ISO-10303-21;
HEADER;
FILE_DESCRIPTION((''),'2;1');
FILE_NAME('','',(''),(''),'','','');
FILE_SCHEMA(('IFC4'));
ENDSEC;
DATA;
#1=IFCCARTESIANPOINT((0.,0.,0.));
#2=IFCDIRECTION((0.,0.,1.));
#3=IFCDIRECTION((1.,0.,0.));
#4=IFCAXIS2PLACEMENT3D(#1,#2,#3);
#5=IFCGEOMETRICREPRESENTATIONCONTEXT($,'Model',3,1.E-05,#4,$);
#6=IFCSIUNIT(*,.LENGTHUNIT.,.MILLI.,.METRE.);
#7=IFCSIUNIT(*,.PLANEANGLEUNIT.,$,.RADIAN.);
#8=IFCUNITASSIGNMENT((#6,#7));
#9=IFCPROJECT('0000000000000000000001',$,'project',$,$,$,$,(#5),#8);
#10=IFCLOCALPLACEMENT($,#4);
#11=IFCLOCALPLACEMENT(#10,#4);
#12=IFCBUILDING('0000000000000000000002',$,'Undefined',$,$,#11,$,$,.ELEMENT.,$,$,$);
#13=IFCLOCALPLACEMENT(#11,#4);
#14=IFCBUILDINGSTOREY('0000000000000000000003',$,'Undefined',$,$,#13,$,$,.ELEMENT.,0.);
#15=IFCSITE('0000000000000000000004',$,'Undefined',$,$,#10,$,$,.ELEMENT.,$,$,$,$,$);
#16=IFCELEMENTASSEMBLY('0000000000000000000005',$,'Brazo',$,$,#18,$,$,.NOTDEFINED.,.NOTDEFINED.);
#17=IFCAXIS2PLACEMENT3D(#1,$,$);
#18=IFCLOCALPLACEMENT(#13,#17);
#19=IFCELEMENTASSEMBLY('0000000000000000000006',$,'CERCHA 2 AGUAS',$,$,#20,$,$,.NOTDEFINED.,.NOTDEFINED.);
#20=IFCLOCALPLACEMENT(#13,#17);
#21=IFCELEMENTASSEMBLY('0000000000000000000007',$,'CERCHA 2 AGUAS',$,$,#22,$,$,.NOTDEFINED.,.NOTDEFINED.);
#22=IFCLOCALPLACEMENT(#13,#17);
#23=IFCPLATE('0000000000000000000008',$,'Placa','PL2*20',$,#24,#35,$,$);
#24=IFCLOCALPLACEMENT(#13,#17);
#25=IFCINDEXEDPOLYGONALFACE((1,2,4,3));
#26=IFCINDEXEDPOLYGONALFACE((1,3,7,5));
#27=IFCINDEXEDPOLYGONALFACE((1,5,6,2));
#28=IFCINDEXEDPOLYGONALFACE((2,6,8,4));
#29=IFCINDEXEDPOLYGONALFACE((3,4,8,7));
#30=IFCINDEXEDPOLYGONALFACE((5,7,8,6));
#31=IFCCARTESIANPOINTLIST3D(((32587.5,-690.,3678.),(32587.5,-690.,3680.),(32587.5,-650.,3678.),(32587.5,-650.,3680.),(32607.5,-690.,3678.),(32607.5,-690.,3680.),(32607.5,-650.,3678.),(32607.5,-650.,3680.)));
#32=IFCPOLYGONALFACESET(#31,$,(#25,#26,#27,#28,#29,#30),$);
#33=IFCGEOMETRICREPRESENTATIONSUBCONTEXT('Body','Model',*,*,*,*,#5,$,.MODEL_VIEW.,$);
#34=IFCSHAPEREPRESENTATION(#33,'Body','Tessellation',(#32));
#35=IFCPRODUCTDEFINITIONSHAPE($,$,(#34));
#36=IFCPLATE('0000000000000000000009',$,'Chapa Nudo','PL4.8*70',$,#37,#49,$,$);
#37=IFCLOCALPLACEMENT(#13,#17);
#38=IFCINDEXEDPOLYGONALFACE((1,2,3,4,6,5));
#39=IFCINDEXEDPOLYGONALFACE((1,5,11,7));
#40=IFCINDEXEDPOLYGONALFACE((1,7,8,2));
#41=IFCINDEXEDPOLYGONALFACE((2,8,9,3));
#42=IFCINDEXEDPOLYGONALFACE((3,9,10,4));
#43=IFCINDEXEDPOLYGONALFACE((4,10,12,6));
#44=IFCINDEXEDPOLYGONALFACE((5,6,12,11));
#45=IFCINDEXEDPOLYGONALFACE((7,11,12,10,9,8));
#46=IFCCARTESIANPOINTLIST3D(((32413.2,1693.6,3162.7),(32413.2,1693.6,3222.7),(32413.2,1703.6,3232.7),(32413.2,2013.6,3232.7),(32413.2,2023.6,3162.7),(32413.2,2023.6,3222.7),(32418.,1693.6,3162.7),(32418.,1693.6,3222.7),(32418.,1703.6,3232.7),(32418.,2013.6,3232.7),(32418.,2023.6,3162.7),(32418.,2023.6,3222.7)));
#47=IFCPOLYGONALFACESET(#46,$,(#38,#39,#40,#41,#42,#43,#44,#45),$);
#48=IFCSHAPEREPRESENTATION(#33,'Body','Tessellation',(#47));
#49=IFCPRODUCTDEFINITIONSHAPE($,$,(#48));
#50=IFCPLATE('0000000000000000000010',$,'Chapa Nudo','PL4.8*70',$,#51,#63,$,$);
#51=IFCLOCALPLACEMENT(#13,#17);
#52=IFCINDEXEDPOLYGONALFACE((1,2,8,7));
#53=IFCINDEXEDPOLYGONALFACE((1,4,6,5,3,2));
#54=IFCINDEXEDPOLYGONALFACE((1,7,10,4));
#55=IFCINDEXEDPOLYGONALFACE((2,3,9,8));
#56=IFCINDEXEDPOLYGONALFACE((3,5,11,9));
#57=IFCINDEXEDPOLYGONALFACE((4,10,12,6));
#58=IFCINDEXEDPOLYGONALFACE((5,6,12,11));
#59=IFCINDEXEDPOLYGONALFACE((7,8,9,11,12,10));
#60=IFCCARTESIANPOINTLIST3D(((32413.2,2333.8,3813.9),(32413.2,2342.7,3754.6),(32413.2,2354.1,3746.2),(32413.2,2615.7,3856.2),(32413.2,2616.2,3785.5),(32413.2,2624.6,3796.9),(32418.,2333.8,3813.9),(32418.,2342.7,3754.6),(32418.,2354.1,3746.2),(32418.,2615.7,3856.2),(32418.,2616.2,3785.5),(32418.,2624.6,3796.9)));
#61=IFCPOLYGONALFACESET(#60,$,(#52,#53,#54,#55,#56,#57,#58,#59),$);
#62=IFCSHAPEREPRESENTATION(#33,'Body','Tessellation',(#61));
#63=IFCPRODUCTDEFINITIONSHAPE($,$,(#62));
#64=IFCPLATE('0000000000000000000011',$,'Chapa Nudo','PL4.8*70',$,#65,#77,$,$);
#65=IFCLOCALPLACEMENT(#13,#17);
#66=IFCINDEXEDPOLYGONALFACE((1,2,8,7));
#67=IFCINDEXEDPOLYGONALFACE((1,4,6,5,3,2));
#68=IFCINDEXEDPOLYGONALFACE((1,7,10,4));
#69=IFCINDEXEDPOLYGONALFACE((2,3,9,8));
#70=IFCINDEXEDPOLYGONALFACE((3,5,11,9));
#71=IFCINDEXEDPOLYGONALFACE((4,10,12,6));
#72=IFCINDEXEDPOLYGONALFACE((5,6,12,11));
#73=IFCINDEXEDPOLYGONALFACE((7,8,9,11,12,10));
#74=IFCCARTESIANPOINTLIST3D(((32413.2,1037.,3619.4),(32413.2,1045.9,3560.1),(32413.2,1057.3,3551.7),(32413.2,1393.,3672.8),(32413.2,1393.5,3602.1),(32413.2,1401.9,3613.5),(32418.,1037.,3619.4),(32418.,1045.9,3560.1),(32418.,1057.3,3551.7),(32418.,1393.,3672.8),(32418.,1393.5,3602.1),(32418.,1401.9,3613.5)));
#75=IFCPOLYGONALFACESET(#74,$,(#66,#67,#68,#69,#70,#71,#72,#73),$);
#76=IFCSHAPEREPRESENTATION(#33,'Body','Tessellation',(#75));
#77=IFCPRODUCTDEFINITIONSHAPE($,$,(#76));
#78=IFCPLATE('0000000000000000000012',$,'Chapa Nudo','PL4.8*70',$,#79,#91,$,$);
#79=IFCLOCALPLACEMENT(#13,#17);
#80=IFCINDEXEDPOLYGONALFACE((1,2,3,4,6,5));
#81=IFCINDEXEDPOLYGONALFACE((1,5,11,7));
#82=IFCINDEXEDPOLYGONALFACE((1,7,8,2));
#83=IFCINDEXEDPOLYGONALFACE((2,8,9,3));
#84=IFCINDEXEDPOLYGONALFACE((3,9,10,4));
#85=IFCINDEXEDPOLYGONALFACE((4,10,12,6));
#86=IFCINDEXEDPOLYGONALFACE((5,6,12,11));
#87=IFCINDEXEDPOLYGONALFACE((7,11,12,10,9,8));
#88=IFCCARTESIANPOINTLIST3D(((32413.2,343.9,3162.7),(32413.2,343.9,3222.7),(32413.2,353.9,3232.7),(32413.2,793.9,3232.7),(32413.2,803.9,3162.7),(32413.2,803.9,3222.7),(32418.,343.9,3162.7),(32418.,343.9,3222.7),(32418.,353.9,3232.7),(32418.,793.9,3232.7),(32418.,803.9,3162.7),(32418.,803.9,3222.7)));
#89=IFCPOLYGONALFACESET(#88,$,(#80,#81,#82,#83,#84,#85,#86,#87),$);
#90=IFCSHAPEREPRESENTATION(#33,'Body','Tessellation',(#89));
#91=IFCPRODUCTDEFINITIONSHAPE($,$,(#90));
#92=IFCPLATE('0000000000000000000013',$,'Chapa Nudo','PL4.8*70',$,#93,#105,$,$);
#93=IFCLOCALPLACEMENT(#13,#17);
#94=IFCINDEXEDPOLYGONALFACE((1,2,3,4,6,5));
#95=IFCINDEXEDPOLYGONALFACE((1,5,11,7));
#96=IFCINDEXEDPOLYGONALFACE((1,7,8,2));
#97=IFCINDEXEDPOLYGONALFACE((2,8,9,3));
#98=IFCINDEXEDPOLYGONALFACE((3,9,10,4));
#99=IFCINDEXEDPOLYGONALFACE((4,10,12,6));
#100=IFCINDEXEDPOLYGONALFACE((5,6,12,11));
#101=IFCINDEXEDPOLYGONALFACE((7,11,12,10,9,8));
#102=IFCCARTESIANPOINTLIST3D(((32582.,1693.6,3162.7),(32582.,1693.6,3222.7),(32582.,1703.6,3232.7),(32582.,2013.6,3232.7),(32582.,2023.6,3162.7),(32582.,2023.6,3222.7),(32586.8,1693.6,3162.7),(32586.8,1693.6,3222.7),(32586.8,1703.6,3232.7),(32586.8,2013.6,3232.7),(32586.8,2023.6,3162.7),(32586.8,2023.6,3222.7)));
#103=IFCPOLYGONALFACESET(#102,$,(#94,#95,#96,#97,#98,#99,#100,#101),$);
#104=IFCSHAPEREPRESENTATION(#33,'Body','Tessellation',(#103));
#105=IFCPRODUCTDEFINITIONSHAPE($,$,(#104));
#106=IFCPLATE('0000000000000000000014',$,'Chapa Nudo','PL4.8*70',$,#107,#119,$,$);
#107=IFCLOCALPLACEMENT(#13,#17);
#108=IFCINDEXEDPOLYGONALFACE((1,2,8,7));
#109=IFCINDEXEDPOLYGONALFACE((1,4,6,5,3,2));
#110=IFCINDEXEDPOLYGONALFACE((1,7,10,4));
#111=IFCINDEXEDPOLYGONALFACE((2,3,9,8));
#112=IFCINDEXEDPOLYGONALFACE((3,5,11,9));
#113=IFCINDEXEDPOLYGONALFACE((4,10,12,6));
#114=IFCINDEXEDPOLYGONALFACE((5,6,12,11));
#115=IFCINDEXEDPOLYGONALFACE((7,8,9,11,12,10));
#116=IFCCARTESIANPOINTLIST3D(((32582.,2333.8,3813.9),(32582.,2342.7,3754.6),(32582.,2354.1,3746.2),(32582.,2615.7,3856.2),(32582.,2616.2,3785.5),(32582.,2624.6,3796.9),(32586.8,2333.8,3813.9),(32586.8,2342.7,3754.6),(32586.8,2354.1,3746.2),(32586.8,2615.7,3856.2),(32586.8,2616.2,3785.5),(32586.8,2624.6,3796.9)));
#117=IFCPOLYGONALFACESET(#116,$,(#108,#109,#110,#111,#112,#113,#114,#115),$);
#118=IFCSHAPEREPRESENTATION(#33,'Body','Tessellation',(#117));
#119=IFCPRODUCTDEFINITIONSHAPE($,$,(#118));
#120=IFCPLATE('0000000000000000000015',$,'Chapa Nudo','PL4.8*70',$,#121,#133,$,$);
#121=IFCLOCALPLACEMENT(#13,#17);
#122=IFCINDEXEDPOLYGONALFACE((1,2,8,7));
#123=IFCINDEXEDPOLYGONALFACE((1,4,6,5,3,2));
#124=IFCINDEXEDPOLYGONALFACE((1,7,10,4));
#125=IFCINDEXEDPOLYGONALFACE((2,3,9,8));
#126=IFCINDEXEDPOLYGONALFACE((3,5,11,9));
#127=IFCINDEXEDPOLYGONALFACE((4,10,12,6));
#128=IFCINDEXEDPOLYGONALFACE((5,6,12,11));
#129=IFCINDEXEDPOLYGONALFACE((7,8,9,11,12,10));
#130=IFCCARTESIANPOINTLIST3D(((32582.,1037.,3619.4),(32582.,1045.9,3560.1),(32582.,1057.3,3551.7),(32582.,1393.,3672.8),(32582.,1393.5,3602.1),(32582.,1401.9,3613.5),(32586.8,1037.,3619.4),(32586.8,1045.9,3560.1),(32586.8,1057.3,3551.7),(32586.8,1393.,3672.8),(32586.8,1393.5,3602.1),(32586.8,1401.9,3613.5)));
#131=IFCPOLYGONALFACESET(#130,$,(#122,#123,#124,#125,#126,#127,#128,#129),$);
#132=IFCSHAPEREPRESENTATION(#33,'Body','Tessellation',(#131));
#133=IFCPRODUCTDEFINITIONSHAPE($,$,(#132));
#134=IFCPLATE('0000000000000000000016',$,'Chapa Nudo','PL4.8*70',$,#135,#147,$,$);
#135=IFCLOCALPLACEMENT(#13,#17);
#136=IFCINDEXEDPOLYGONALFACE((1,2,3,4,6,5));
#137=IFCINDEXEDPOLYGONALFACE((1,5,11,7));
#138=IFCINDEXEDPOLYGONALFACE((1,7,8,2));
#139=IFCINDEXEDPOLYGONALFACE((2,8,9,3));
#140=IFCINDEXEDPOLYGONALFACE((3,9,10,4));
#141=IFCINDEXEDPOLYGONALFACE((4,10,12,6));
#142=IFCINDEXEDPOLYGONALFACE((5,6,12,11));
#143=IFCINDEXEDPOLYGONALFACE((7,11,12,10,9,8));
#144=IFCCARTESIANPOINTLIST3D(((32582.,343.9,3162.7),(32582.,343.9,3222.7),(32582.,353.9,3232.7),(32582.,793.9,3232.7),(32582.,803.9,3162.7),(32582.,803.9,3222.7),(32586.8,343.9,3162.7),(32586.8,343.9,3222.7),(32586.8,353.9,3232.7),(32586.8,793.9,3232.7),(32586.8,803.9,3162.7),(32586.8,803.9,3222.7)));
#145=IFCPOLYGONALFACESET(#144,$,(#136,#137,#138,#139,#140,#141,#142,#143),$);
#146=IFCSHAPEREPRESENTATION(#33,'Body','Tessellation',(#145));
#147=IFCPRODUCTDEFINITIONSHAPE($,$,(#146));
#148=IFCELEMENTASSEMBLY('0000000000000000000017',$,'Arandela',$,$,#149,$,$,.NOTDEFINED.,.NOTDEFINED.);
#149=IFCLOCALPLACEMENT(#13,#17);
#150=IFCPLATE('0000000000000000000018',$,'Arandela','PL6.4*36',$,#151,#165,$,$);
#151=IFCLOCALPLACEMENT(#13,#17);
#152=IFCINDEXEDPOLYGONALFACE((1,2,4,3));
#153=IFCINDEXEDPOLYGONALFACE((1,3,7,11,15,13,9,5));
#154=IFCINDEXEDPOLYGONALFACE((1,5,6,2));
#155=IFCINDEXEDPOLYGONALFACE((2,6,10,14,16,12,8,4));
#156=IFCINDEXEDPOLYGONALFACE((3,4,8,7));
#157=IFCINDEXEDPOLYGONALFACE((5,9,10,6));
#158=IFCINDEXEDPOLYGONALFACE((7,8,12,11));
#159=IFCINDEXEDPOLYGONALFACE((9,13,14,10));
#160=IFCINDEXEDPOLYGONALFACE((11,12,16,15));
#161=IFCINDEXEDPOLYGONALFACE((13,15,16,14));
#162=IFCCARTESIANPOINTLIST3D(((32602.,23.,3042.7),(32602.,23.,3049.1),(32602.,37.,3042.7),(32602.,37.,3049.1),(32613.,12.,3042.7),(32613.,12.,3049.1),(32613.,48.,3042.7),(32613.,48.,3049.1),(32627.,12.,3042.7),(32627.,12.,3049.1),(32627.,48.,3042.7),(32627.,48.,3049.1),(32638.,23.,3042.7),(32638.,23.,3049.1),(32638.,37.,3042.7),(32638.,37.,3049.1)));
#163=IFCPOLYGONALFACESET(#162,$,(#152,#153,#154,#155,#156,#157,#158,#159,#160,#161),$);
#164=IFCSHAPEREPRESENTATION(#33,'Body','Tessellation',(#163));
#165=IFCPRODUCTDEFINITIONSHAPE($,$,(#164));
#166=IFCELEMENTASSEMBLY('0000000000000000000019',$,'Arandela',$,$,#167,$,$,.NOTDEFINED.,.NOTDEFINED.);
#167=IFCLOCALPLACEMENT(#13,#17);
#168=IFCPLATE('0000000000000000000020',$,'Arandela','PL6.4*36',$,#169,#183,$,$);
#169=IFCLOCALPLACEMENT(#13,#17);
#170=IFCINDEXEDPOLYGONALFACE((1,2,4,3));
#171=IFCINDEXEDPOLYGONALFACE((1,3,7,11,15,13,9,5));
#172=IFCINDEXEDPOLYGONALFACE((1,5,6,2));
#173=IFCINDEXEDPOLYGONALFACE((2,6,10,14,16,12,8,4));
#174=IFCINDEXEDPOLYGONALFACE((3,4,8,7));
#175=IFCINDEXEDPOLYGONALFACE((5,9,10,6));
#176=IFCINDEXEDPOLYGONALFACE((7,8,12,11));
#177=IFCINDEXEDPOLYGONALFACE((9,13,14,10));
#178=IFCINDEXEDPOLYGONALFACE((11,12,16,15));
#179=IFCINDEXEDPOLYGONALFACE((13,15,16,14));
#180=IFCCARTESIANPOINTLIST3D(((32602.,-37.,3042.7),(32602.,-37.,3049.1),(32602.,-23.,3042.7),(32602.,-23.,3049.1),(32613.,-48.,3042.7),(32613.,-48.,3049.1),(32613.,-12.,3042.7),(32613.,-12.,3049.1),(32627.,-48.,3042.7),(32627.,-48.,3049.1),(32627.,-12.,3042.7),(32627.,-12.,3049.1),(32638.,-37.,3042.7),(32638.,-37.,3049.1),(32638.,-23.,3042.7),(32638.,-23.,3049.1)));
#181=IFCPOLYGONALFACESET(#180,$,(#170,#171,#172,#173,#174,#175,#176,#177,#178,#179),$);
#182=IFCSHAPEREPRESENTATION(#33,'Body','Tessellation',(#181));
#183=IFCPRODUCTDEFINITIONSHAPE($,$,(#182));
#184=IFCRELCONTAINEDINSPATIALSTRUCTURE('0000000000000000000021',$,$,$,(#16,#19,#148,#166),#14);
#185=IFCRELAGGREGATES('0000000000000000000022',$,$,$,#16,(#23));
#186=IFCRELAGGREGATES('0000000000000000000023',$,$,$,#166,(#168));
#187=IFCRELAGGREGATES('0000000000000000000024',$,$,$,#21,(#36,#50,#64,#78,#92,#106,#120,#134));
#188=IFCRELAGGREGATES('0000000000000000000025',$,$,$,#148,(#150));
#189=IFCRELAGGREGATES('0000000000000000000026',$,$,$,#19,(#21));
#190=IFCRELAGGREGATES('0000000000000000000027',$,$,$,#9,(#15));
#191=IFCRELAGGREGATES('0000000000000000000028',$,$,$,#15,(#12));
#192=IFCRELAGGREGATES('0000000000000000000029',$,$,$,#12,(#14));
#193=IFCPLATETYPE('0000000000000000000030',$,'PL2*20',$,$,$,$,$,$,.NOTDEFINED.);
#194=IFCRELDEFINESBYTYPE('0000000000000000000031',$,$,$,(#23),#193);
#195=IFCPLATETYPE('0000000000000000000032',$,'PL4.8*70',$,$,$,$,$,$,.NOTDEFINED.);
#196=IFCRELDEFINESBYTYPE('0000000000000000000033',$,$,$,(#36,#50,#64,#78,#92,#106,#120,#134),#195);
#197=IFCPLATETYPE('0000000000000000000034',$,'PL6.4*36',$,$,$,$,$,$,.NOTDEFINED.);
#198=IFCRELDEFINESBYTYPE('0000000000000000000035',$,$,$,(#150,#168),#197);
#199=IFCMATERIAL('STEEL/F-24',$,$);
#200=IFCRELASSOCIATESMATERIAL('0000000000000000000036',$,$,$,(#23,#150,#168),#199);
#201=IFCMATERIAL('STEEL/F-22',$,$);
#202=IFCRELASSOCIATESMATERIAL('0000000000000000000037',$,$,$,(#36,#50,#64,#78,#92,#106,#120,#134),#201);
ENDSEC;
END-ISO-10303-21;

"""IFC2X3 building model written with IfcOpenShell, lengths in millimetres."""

from ifc_helpers import new_model, si_unit, frame, origin_with_axes, place, context, subcontext, project, spatial, polyline, outline, extrude, material, type_object, element, aggregate, save


model = new_model("IFC2X3")

# Units and contexts
model_context = context("Model", 3, precision=1e-05, world=origin_with_axes())
body_context = subcontext(model_context, "Body", "Model", "MODEL_VIEW")
ifc_project = project(units=[si_unit("LENGTHUNIT", "METRE", prefix="MILLI"), si_unit("PLANEANGLEUNIT", "RADIAN")], contexts=[model_context])

# Site, building, storey
site_placement = place(None, origin_with_axes())
site = spatial("IfcSite", under=ifc_project, at=site_placement, Name="Undefined", CompositionType="ELEMENT")
building_placement = place(site_placement, origin_with_axes())
building = spatial("IfcBuilding", under=site, at=building_placement, Name="Undefined", CompositionType="ELEMENT")
storey_placement = place(building_placement, origin_with_axes())
storey = spatial("IfcBuildingStorey", under=building, at=storey_placement, Name="Undefined", CompositionType="ELEMENT", Elevation=0.0)

# Element assembly
assembly_1_placement = place(storey_placement, origin_with_axes())
assembly_1 = element("IfcElementAssembly", 1, at=assembly_1_placement, inside=storey, Name="Brazo", AssemblyPlace="NOTDEFINED", PredefinedType="NOTDEFINED")

# Element assemblies
assembly_2_placement = place(storey_placement, origin_with_axes())
assembly_2 = element("IfcElementAssembly", 2, at=assembly_2_placement, inside=storey, Name="CERCHA 2 AGUAS", AssemblyPlace="NOTDEFINED", PredefinedType="NOTDEFINED")
assembly_3_placement = place(assembly_2_placement, origin_with_axes())
assembly_3 = element("IfcElementAssembly", 3, at=assembly_3_placement, Name="CERCHA 2 AGUAS", AssemblyPlace="NOTDEFINED", PredefinedType="NOTDEFINED")
ifc_material_1 = material(Name="STEEL/F-22")

# Shared definitions
ifc_material_2 = material(Name="STEEL/F-24")

# Plates
plate_type_1 = type_object("IfcPlateType", Name="PL2*20", PredefinedType="NOTDEFINED")
plate_1_placement = place(assembly_1_placement, frame((32587.5, -690.0, 3679.0), z_axis=(0.0, 0.000121, -1.0), x_axis=(-0.000071, 1.0, 0.000121)))
plate_1 = element("IfcPlate", 4, at=plate_1_placement, type_object=plate_type_1, material=ifc_material_2, Name="Placa", Description="PL2*20", context=body_context, shape_type="SweptSolid", body=[
    extrude(outline(polyline([(0.0, 0.0), (40.0, 0.0), (40.0, 20.0), (0.0, 20.0), (0.0, 0.0)])), frame((0.0, 0.0, -1.0), z_axis=(0.0, 0.0, 1.0), x_axis=(1.0, 0.0, 0.0)), (0.0, 0.0, 1.0), 2.0),
])
aggregate(assembly_1, [plate_1])
plate_type_2 = type_object("IfcPlateType", Name="PL4.8*70", PredefinedType="NOTDEFINED")
plate_2_placement = place(assembly_3_placement, frame((32415.6, 1693.6, 3232.7), z_axis=(1.0, 0.0, 0.0), x_axis=(0.0, 0.0, -1.0)))
plate_2 = element("IfcPlate", 5, at=plate_2_placement, type_object=plate_type_2, material=ifc_material_1, Name="Chapa Nudo", Description="PL4.8*70", context=body_context, shape_type="SweptSolid", body=[
    extrude(outline(polyline([(0.0, 10.0), (10.0, 0.0), (70.0, 0.0), (70.0, 330.0), (10.0, 330.0), (0.0, 320.0), (0.0, 10.0)])), frame((0.0, 0.0, -2.4), z_axis=(0.0, 0.0, 1.0), x_axis=(1.0, 0.0, 0.0)), (0.0, 0.0, 1.0), 4.8),
])
plate_3_placement = place(assembly_3_placement, frame((32415.6, 2333.8, 3813.9), z_axis=(1.0, 0.0, 0.0), x_axis=(0.0, 0.14834, -0.988936)))
plate_3 = element("IfcPlate", 6, at=plate_3_placement, type_object=plate_type_2, material=ifc_material_1, Name="Chapa Nudo", Description="PL4.8*70", context=body_context, shape_type="SweptSolid", body=[
    extrude(outline(polyline([(0.0, 0.0), (60.0, 0.0), (70.0, 10.0), (70.0, 275.0), (60.0, 285.0), (0.0, 285.0), (0.0, 0.0)])), frame((0.0, 0.0, -2.4), z_axis=(0.0, 0.0, 1.0), x_axis=(1.0, 0.0, 0.0)), (0.0, 0.0, 1.0), 4.8),
])
plate_4_placement = place(assembly_3_placement, frame((32415.6, 1037.0, 3619.4), z_axis=(1.0, 0.0, 0.0), x_axis=(0.0, 0.148337, -0.988937)))
plate_4 = element("IfcPlate", 7, at=plate_4_placement, type_object=plate_type_2, material=ifc_material_1, Name="Chapa Nudo", Description="PL4.8*70", context=body_context, shape_type="SweptSolid", body=[
    extrude(outline(polyline([(0.0, 0.0), (60.0, 0.0), (70.0, 10.0), (70.0, 350.0), (60.0, 360.0), (0.0, 360.0), (0.0, 0.0)])), frame((0.0, 0.0, -2.4), z_axis=(0.0, 0.0, 1.0), x_axis=(1.0, 0.0, 0.0)), (0.0, 0.0, 1.0), 4.8),
])
plate_5_placement = place(assembly_3_placement, frame((32415.6, 343.9, 3232.7), z_axis=(1.0, 0.0, 0.0), x_axis=(0.0, 0.0, -1.0)))
plate_5 = element("IfcPlate", 8, at=plate_5_placement, type_object=plate_type_2, material=ifc_material_1, Name="Chapa Nudo", Description="PL4.8*70", context=body_context, shape_type="SweptSolid", body=[
    extrude(outline(polyline([(0.0, 10.0), (10.0, 0.0), (70.0, 0.0), (70.0, 460.0), (10.0, 460.0), (0.0, 450.0), (0.0, 10.0)])), frame((0.0, 0.0, -2.4), z_axis=(0.0, 0.0, 1.0), x_axis=(1.0, 0.0, 0.0)), (0.0, 0.0, 1.0), 4.8),
])
plate_6_placement = place(assembly_3_placement, frame((32584.4, 1693.6, 3232.7), z_axis=(1.0, 0.0, 0.0), x_axis=(0.0, 0.0, -1.0)))
plate_6 = element("IfcPlate", 9, at=plate_6_placement, type_object=plate_type_2, material=ifc_material_1, Name="Chapa Nudo", Description="PL4.8*70", context=body_context, shape_type="SweptSolid", body=[
    extrude(outline(polyline([(0.0, 10.0), (10.0, 0.0), (70.0, 0.0), (70.0, 330.0), (10.0, 330.0), (0.0, 320.0), (0.0, 10.0)])), frame((0.0, 0.0, -2.4), z_axis=(0.0, 0.0, 1.0), x_axis=(1.0, 0.0, 0.0)), (0.0, 0.0, 1.0), 4.8),
])
plate_7_placement = place(assembly_3_placement, frame((32584.4, 2333.8, 3813.9), z_axis=(1.0, 0.0, 0.0), x_axis=(0.0, 0.14834, -0.988936)))
plate_7 = element("IfcPlate", 10, at=plate_7_placement, type_object=plate_type_2, material=ifc_material_1, Name="Chapa Nudo", Description="PL4.8*70", context=body_context, shape_type="SweptSolid", body=[
    extrude(outline(polyline([(0.0, 0.0), (60.0, 0.0), (70.0, 10.0), (70.0, 275.0), (60.0, 285.0), (0.0, 285.0), (0.0, 0.0)])), frame((0.0, 0.0, -2.4), z_axis=(0.0, 0.0, 1.0), x_axis=(1.0, 0.0, 0.0)), (0.0, 0.0, 1.0), 4.8),
])
plate_8_placement = place(assembly_3_placement, frame((32584.4, 1037.0, 3619.4), z_axis=(1.0, 0.0, 0.0), x_axis=(0.0, 0.148337, -0.988937)))
plate_8 = element("IfcPlate", 11, at=plate_8_placement, type_object=plate_type_2, material=ifc_material_1, Name="Chapa Nudo", Description="PL4.8*70", context=body_context, shape_type="SweptSolid", body=[
    extrude(outline(polyline([(0.0, 0.0), (60.0, 0.0), (70.0, 10.0), (70.0, 350.0), (60.0, 360.0), (0.0, 360.0), (0.0, 0.0)])), frame((0.0, 0.0, -2.4), z_axis=(0.0, 0.0, 1.0), x_axis=(1.0, 0.0, 0.0)), (0.0, 0.0, 1.0), 4.8),
])
plate_9_placement = place(assembly_3_placement, frame((32584.4, 343.9, 3232.7), z_axis=(1.0, 0.0, 0.0), x_axis=(0.0, 0.0, -1.0)))
plate_9 = element("IfcPlate", 12, at=plate_9_placement, type_object=plate_type_2, material=ifc_material_1, Name="Chapa Nudo", Description="PL4.8*70", context=body_context, shape_type="SweptSolid", body=[
    extrude(outline(polyline([(0.0, 10.0), (10.0, 0.0), (70.0, 0.0), (70.0, 460.0), (10.0, 460.0), (0.0, 450.0), (0.0, 10.0)])), frame((0.0, 0.0, -2.4), z_axis=(0.0, 0.0, 1.0), x_axis=(1.0, 0.0, 0.0)), (0.0, 0.0, 1.0), 4.8),
])

# Element assemblies, plates
assembly_4_placement = place(storey_placement, origin_with_axes())
assembly_4 = element("IfcElementAssembly", 13, at=assembly_4_placement, inside=storey, Name="Arandela", AssemblyPlace="NOTDEFINED", PredefinedType="NOTDEFINED")
plate_type_3 = type_object("IfcPlateType", Name="PL6.4*36", PredefinedType="NOTDEFINED")
plate_10_placement = place(assembly_4_placement, frame((32602.0, 48.0, 3045.9), z_axis=(0.0, 0.0, 1.0), x_axis=(0.0, -1.0, 0.0)))
plate_10 = element("IfcPlate", 14, at=plate_10_placement, type_object=plate_type_3, material=ifc_material_2, Name="Arandela", Description="PL6.4*36", context=body_context, shape_type="SweptSolid", body=[
    extrude(outline(polyline([(0.0, 11.0), (11.0, 0.0), (25.0, 0.0), (36.0, 11.0), (36.0, 25.0), (25.0, 36.0), (11.0, 36.0), (0.0, 25.0), (0.0, 11.0)])), frame((0.0, 0.0, -3.2), z_axis=(0.0, 0.0, 1.0), x_axis=(1.0, 0.0, 0.0)), (0.0, 0.0, 1.0), 6.4),
])
assembly_5_placement = place(storey_placement, origin_with_axes())
assembly_5 = element("IfcElementAssembly", 15, at=assembly_5_placement, inside=storey, Name="Arandela", AssemblyPlace="NOTDEFINED", PredefinedType="NOTDEFINED")
plate_11_placement = place(assembly_5_placement, frame((32602.0, -12.0, 3045.9), z_axis=(0.0, 0.0, 1.0), x_axis=(0.0, -1.0, 0.0)))
plate_11 = element("IfcPlate", 16, at=plate_11_placement, type_object=plate_type_3, material=ifc_material_2, Name="Arandela", Description="PL6.4*36", context=body_context, shape_type="SweptSolid", body=[
    extrude(outline(polyline([(0.0, 11.0), (11.0, 0.0), (25.0, 0.0), (36.0, 11.0), (36.0, 25.0), (25.0, 36.0), (11.0, 36.0), (0.0, 25.0), (0.0, 11.0)])), frame((0.0, 0.0, -3.2), z_axis=(0.0, 0.0, 1.0), x_axis=(1.0, 0.0, 0.0)), (0.0, 0.0, 1.0), 6.4),
])
aggregate(assembly_5, [plate_11])

aggregate(assembly_3, [plate_2, plate_3, plate_4, plate_5, plate_6, plate_7, plate_8, plate_9])
aggregate(assembly_4, [plate_10])
aggregate(assembly_2, [assembly_3])

save(model, "model.ifc")
